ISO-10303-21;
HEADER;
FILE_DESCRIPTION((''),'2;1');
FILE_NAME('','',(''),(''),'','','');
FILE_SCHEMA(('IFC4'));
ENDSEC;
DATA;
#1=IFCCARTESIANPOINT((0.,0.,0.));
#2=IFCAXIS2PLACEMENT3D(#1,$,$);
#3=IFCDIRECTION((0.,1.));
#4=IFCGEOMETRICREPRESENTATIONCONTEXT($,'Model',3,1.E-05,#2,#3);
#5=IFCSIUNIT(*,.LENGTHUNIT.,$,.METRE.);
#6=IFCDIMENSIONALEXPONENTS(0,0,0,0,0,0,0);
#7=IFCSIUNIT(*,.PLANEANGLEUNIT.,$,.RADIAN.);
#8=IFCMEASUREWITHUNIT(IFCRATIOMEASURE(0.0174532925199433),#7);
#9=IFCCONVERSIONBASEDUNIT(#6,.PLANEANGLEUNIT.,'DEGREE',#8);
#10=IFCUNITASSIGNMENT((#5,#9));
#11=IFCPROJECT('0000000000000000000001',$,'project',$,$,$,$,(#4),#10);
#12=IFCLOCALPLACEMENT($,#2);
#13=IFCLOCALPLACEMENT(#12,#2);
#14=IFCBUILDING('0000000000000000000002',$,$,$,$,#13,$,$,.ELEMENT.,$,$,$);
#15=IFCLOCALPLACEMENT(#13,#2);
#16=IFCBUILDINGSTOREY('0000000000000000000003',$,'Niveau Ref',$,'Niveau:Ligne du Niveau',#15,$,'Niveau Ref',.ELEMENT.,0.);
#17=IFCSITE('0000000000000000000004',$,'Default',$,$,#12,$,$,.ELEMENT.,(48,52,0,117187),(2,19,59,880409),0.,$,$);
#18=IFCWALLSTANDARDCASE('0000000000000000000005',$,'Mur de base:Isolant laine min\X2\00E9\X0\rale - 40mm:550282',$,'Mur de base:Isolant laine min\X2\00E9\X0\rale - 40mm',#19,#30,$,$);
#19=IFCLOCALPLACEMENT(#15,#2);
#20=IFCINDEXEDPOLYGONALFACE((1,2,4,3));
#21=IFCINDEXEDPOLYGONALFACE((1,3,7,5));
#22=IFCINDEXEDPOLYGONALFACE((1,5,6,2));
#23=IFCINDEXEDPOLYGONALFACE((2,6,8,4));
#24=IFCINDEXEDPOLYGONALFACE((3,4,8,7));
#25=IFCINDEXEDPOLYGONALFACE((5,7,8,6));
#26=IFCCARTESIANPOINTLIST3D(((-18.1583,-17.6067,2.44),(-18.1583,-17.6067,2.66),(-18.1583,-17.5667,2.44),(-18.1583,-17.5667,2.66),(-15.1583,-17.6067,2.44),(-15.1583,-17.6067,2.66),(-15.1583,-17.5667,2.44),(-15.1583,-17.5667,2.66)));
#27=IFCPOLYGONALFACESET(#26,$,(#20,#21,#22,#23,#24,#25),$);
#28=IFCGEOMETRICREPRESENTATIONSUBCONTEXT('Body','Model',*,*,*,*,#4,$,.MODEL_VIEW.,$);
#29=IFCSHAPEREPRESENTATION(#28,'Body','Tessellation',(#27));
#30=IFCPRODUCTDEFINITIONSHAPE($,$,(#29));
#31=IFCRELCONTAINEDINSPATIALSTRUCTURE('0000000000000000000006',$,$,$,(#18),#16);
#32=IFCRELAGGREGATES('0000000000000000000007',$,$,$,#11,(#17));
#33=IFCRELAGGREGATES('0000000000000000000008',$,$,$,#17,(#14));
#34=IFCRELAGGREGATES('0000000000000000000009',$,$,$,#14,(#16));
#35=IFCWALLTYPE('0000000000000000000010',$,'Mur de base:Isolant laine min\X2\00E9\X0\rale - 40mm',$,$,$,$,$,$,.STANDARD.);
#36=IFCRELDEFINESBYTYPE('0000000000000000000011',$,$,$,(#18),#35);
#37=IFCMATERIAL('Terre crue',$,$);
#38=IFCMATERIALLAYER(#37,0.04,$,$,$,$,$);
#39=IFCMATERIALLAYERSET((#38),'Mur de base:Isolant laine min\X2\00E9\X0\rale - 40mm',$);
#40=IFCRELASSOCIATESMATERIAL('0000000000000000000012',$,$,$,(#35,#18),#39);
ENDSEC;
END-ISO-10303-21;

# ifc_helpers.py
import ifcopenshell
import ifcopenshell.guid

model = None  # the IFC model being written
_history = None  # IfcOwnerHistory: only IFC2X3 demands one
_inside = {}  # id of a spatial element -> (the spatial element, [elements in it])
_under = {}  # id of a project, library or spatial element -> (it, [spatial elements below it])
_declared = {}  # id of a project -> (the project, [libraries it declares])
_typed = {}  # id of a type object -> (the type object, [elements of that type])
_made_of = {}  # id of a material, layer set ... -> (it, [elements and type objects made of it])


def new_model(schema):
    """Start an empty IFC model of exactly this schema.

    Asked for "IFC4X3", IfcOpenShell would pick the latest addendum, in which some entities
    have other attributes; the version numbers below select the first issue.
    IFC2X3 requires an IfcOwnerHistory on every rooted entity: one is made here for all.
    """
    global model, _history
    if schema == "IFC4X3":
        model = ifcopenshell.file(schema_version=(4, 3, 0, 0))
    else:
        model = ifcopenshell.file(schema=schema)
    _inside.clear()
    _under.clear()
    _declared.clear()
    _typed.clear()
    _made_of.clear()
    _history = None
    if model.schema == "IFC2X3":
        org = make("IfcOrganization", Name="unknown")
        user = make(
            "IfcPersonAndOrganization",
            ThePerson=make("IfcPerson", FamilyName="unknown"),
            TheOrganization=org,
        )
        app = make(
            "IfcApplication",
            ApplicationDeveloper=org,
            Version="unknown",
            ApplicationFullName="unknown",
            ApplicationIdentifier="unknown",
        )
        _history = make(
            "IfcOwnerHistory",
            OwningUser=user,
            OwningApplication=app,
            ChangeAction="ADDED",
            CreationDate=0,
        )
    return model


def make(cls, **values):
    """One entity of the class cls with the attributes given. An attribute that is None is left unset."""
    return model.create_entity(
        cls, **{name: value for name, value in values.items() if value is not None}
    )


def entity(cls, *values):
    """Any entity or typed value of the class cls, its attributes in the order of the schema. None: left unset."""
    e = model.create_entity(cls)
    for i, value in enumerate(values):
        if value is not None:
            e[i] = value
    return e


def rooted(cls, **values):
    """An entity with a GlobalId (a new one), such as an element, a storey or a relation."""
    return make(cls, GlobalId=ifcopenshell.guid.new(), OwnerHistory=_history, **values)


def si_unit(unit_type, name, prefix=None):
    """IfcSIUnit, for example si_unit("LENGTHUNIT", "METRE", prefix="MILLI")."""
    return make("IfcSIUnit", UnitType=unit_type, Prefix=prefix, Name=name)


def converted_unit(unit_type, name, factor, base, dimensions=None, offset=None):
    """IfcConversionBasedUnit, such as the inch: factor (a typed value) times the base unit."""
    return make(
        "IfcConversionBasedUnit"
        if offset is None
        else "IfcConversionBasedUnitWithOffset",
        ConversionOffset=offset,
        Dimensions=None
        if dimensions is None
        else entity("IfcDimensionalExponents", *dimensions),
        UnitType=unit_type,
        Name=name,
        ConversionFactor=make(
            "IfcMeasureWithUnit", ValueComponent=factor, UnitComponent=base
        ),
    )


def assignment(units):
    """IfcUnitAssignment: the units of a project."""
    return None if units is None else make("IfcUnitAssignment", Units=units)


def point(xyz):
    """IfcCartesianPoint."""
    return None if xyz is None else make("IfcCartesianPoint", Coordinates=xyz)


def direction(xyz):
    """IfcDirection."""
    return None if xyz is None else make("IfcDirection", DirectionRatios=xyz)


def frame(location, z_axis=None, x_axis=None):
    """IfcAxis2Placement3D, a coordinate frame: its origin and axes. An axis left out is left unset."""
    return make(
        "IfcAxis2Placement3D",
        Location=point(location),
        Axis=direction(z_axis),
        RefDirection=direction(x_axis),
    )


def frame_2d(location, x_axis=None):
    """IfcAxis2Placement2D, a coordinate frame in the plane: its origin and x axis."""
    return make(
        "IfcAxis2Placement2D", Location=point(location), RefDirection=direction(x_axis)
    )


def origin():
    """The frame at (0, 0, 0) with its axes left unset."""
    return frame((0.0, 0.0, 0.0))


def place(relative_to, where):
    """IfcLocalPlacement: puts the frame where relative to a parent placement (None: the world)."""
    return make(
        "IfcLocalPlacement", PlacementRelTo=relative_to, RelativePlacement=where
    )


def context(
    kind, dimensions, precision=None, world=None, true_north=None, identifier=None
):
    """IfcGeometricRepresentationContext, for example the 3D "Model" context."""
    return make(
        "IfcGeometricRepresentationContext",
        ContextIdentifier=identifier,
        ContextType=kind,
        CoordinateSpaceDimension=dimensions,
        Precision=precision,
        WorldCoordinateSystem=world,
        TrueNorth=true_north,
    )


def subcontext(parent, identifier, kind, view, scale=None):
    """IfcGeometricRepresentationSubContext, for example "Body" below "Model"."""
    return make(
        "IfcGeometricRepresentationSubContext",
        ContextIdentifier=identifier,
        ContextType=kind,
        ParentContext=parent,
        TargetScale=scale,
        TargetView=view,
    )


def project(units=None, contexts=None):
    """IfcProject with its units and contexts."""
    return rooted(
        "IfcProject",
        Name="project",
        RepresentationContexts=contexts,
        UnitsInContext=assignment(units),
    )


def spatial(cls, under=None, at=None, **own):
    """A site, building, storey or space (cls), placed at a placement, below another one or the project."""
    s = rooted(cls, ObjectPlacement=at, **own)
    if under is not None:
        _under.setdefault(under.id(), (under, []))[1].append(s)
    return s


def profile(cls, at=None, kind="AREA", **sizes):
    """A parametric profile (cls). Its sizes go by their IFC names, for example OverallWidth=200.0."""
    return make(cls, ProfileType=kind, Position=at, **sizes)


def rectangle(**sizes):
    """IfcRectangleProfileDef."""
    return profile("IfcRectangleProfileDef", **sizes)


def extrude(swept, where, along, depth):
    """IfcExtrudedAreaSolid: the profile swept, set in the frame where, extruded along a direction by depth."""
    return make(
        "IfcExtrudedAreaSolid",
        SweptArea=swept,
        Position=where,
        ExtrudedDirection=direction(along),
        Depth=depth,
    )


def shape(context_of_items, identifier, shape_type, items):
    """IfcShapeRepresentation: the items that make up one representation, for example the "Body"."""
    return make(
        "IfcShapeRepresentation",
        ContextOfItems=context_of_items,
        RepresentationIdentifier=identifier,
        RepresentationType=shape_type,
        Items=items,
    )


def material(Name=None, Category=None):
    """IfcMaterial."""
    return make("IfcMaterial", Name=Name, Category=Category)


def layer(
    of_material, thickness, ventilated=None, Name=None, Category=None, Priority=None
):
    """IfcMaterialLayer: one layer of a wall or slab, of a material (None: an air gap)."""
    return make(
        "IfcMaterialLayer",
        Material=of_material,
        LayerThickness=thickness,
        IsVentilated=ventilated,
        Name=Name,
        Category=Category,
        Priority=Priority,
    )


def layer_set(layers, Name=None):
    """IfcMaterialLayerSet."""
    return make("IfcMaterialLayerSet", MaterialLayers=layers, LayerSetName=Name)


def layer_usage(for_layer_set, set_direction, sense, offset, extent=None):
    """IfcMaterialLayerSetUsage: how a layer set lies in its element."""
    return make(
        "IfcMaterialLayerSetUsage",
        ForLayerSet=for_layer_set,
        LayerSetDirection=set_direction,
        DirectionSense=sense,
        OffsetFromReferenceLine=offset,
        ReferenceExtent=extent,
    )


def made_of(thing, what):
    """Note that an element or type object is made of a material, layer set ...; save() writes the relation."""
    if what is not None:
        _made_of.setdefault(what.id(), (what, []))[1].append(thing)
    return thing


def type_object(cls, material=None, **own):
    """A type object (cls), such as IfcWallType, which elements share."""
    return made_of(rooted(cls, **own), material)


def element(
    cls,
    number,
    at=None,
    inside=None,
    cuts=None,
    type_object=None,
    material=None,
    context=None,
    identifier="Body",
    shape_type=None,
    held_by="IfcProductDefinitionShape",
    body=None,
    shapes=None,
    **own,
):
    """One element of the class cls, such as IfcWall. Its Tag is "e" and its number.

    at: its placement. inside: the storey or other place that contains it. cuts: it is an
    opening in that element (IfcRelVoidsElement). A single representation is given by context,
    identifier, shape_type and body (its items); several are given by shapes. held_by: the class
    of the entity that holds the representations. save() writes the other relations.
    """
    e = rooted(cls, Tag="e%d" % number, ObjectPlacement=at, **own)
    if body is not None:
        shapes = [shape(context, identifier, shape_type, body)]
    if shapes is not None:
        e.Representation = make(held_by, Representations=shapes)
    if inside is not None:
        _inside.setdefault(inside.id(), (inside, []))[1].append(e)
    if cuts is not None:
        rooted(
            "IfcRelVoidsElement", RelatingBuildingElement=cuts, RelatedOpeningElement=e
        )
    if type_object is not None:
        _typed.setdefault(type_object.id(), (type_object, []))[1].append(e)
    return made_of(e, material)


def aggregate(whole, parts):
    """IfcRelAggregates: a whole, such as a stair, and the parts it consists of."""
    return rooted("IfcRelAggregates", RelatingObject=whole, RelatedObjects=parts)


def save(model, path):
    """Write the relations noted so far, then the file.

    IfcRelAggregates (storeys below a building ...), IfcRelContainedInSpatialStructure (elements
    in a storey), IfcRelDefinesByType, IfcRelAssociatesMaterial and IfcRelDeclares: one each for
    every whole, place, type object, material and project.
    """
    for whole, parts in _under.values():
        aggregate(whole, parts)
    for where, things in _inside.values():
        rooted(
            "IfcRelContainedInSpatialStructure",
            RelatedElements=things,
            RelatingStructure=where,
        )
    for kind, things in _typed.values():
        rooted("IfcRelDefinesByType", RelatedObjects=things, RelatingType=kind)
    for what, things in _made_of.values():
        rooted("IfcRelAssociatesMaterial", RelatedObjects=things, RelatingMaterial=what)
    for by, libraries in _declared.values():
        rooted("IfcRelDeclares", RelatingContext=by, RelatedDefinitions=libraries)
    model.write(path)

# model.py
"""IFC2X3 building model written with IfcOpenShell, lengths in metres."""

from ifc_helpers import new_model, entity, si_unit, converted_unit, direction, frame, frame_2d, origin, place, context, subcontext, project, spatial, rectangle, extrude, material, layer, layer_set, layer_usage, type_object, element, save


model = new_model("IFC2X3")

# Units and contexts
model_context = context("Model", 3, precision=1e-05, world=origin(), true_north=direction((0.0, 1.0)))
body_context = subcontext(model_context, "Body", "Model", "MODEL_VIEW")
ifc_project = project(units=[si_unit("LENGTHUNIT", "METRE"), converted_unit("PLANEANGLEUNIT", "DEGREE", entity("IfcRatioMeasure", 0.0174532925199433), si_unit("PLANEANGLEUNIT", "RADIAN"), dimensions=[0, 0, 0, 0, 0, 0, 0])], contexts=[model_context])

# Site, building, storey
site_placement = place(None, origin())
site = spatial("IfcSite", under=ifc_project, at=site_placement, Name="Default", CompositionType="ELEMENT", RefLatitude=(48, 52, 0, 117187), RefLongitude=(2, 19, 59, 880409), RefElevation=0.0)
building_placement = place(site_placement, origin())
building = spatial("IfcBuilding", under=site, at=building_placement, CompositionType="ELEMENT")
storey_placement = place(building_placement, origin())
storey = spatial("IfcBuildingStorey", under=building, at=storey_placement, Name="Niveau Ref", ObjectType="Niveau:Ligne du Niveau", LongName="Niveau Ref", CompositionType="ELEMENT", Elevation=0.0)

# Wall
ifc_material_1 = material(Name="Terre crue")
ifc_layer = layer(ifc_material_1, 0.04)
ifc_layer_set = layer_set([ifc_layer], Name="Mur de base:Isolant laine minérale - 40mm")
wall_type = type_object("IfcWallType", Name="Mur de base:Isolant laine minérale - 40mm", PredefinedType="STANDARD", material=ifc_layer_set)
ifc_layer_usage_1 = layer_usage(ifc_layer_set, "AXIS2", "NEGATIVE", 0.02)
wall_1_placement = place(storey_placement, frame((-18.1583, -17.5867, 2.44)))
element("IfcWallStandardCase", 1, at=wall_1_placement, inside=storey, type_object=wall_type, material=ifc_layer_usage_1, Name="Mur de base:Isolant laine minérale - 40mm:550282", ObjectType="Mur de base:Isolant laine minérale - 40mm", context=body_context, shape_type="SweptSolid", body=[
    extrude(rectangle(XDim=3.0, YDim=0.04, at=frame_2d((1.5, 0.0), x_axis=(-1.0, 0.0))), origin(), (0.0, 0.0, 1.0), 0.22),
])

save(model, "model.ifc")
